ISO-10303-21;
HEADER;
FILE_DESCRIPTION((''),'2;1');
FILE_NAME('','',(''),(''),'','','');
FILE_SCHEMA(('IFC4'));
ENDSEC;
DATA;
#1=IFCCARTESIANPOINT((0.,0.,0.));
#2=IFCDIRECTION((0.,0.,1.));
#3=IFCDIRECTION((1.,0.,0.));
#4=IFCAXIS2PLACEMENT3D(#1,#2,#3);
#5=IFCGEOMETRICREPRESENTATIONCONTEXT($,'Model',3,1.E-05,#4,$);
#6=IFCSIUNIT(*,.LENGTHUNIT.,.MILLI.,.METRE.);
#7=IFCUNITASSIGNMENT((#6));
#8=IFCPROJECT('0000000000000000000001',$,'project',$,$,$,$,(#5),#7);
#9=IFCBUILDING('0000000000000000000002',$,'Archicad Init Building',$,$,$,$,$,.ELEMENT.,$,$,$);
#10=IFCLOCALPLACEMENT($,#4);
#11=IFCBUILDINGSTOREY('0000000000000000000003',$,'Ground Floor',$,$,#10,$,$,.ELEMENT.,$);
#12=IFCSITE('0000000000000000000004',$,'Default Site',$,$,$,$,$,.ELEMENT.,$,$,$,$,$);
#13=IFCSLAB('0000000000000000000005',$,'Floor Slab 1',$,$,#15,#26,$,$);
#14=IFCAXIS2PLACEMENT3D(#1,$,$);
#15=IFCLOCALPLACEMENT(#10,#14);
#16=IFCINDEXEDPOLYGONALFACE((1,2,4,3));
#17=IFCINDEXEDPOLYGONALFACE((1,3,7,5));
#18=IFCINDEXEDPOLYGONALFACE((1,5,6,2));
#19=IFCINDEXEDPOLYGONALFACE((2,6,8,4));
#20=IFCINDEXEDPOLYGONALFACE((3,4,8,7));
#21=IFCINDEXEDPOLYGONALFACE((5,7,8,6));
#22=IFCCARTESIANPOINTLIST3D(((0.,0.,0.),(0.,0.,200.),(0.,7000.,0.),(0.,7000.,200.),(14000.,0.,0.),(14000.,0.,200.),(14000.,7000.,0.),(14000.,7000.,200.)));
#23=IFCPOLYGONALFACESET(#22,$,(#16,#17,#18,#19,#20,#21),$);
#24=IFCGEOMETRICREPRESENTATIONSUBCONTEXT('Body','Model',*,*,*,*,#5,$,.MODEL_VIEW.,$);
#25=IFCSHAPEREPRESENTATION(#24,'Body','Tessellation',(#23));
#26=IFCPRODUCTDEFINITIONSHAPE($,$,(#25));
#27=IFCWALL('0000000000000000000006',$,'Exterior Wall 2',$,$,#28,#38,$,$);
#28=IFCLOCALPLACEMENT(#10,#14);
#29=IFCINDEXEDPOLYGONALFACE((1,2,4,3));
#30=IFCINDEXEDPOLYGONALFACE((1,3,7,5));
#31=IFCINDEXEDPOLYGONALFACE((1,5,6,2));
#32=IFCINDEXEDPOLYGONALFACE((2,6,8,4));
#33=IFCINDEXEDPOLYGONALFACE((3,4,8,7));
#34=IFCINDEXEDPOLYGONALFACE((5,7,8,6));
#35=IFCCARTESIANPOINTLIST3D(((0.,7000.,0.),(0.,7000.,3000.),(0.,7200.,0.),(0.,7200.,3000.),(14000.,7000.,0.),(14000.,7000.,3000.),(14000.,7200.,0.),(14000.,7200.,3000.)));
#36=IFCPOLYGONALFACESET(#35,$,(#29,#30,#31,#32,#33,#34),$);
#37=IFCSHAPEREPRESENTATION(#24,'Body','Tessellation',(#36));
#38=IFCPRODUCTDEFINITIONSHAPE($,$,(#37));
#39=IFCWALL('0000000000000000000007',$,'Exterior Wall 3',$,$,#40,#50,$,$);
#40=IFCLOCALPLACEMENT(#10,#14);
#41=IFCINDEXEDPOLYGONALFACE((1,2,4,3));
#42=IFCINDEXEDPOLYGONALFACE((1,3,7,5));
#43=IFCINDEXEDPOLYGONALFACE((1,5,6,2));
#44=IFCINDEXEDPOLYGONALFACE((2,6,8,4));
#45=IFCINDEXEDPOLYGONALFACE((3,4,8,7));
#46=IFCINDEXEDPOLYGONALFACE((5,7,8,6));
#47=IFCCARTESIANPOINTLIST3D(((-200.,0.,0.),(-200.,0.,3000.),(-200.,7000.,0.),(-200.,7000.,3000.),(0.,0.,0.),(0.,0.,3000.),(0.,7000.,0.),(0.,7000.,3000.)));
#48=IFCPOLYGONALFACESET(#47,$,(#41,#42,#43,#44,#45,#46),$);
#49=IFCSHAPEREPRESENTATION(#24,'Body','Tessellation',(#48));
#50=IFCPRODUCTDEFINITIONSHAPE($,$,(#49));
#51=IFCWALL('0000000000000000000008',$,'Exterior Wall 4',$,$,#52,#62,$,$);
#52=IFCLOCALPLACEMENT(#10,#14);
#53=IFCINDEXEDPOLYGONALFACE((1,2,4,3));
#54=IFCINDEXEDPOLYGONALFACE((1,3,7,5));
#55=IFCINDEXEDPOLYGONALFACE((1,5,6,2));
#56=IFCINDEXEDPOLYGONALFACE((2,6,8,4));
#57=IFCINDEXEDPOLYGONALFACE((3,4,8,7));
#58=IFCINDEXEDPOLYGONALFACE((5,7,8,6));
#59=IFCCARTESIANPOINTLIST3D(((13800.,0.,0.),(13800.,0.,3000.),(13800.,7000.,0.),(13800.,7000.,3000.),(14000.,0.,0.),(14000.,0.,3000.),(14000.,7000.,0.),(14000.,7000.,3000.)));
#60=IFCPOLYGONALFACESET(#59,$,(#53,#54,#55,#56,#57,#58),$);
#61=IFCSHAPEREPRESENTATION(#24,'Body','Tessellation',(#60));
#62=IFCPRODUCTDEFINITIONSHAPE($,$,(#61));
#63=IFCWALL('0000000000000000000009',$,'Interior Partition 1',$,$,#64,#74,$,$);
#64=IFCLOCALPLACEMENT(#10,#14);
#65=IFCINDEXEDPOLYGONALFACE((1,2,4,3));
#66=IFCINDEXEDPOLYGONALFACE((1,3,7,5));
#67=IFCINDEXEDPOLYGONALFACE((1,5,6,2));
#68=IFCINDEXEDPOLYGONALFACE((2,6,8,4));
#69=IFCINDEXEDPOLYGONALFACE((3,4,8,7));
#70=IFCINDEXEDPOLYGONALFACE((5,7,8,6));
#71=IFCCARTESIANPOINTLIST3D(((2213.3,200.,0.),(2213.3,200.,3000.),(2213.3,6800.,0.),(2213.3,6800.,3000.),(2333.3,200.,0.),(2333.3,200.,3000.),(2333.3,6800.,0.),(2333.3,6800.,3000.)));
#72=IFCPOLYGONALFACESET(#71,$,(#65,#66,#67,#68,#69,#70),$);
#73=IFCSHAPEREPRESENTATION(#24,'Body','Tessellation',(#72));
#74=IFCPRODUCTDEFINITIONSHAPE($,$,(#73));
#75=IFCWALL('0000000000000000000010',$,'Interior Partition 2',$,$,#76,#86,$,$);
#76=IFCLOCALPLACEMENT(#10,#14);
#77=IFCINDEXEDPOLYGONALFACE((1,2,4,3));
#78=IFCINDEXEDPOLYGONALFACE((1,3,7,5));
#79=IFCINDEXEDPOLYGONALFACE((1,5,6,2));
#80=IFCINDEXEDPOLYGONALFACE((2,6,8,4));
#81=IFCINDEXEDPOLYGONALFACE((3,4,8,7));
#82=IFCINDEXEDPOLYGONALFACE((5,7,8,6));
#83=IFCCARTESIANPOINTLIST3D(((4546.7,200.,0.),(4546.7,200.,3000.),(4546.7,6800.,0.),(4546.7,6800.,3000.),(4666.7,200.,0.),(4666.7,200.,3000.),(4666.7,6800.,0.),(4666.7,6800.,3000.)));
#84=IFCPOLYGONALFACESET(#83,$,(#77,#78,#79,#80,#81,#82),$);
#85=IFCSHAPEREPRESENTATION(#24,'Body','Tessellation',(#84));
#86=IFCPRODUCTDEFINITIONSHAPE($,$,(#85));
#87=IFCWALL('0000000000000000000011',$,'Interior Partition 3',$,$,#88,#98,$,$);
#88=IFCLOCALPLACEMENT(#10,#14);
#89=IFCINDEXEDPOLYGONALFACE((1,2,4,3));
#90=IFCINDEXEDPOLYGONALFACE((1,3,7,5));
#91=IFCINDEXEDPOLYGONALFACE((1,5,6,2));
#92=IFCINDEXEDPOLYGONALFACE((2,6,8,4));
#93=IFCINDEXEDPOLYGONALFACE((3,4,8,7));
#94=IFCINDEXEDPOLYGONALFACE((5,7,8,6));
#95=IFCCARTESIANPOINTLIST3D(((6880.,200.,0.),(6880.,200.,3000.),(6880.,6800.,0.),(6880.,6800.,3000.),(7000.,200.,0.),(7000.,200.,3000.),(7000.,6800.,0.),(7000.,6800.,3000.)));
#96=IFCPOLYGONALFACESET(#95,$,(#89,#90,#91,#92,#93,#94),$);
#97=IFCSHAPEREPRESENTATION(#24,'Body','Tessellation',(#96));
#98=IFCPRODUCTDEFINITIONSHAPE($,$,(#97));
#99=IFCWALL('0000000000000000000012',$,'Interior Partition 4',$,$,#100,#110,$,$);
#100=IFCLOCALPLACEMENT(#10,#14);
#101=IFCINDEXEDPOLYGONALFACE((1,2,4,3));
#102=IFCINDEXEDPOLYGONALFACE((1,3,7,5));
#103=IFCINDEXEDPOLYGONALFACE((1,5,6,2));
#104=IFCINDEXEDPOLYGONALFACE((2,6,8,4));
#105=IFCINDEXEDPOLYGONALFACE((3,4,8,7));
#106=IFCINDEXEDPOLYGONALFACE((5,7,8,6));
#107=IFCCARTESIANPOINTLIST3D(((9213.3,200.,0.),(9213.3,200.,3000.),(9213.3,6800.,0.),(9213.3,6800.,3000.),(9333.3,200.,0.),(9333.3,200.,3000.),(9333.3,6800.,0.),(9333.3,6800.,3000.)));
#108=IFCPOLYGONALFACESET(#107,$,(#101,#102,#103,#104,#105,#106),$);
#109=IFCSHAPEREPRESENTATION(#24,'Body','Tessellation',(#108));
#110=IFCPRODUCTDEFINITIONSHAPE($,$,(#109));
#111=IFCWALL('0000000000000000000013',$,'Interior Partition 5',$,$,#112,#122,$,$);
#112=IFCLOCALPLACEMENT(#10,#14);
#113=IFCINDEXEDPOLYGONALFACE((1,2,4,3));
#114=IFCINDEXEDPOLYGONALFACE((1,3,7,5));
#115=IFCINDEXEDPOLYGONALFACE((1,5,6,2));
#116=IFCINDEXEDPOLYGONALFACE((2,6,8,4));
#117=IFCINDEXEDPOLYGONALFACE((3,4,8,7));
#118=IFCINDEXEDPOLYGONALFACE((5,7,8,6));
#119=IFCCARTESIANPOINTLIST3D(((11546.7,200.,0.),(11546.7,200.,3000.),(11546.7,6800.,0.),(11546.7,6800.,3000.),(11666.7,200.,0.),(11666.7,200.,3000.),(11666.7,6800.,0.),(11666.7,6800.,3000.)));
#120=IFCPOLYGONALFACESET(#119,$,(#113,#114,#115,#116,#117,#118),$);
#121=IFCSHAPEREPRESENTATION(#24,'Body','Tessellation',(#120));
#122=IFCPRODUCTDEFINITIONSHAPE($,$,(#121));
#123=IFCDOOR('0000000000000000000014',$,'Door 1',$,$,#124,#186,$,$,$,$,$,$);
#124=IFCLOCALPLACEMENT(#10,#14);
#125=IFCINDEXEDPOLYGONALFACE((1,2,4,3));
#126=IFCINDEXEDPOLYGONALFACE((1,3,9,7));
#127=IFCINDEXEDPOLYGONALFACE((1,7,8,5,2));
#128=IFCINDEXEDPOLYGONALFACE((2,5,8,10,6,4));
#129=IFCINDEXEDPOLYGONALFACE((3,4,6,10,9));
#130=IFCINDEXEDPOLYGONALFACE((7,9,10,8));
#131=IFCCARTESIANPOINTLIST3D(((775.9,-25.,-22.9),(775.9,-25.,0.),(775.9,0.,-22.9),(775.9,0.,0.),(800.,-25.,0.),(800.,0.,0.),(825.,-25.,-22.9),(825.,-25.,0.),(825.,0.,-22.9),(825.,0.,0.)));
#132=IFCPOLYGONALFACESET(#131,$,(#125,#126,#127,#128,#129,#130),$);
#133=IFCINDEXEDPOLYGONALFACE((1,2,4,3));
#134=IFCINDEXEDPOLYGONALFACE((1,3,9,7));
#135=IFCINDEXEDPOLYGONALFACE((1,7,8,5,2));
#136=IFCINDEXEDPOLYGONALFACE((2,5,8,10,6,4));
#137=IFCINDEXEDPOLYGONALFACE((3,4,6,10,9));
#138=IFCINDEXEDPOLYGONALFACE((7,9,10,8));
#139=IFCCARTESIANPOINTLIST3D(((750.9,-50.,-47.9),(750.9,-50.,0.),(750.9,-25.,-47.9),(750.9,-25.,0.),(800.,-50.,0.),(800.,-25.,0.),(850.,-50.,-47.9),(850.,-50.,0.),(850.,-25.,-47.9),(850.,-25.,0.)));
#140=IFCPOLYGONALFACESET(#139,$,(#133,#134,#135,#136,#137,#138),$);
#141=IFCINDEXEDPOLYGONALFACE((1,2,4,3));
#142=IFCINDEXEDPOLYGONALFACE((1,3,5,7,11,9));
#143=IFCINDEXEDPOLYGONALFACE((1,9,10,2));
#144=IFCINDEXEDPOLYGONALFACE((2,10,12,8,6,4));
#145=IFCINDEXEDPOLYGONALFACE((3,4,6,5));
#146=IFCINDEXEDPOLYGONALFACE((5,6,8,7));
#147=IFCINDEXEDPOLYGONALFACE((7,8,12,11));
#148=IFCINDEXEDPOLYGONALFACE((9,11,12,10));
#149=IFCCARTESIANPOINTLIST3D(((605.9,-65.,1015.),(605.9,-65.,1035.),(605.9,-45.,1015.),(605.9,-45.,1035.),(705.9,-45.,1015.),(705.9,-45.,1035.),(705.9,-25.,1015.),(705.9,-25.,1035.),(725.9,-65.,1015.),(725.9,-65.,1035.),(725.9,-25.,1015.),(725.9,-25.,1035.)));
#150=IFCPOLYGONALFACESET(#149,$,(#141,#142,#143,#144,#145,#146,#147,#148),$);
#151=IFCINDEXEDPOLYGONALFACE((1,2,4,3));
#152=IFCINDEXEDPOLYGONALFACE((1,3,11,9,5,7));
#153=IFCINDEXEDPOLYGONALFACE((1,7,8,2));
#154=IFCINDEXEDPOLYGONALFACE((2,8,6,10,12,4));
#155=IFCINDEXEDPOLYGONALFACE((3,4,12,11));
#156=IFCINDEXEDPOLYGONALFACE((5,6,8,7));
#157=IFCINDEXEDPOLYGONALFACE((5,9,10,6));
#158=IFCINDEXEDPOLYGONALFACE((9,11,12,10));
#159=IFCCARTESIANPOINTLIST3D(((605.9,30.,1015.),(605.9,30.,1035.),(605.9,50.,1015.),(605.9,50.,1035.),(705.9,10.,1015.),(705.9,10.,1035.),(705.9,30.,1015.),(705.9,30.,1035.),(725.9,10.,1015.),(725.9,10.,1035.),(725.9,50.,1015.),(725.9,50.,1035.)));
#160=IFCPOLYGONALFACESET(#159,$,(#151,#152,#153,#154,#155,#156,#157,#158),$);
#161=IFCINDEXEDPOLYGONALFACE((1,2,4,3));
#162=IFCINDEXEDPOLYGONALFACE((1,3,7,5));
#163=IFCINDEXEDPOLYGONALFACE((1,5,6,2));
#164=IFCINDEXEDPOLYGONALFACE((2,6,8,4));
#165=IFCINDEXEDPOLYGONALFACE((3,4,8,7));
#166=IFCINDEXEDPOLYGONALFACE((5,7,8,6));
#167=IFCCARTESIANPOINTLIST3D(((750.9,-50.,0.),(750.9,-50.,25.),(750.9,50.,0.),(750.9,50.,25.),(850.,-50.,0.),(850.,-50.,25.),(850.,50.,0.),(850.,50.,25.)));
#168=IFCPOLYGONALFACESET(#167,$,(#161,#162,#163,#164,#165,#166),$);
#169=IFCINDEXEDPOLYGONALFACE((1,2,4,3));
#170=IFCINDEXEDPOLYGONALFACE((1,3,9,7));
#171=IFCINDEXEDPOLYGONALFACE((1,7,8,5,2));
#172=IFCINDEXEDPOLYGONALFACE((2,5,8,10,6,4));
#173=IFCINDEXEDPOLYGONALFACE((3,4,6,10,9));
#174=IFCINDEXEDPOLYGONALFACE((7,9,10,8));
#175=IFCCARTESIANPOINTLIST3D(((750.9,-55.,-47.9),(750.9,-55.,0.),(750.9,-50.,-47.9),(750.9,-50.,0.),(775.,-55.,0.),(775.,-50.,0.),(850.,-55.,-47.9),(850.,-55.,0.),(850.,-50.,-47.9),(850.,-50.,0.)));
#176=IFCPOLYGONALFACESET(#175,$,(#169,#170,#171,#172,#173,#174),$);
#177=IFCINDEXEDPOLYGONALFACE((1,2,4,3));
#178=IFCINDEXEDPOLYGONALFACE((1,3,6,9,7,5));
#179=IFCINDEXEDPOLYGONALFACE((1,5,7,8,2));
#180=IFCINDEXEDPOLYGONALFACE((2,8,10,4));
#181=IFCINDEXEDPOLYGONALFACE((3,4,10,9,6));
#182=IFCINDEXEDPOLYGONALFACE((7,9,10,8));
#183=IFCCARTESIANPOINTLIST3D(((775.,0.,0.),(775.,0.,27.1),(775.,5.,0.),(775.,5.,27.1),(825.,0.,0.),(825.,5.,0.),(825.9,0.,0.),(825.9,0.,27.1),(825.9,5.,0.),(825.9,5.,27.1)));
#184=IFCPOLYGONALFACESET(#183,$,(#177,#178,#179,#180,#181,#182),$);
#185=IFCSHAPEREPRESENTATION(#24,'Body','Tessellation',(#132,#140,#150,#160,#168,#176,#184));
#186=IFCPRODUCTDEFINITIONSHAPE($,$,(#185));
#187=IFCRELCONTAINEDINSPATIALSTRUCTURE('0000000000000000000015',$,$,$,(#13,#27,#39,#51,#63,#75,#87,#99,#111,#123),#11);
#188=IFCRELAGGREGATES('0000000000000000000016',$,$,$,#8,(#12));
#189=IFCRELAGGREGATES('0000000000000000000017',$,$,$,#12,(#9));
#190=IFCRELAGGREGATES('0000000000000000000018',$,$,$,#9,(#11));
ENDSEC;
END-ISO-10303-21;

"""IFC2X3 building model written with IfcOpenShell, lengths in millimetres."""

from ifc_helpers import new_model, si_unit, frame, origin_with_axes, place, context, subcontext, project, spatial, polyline, outline, extrude, element, save


model = new_model("IFC2X3")

# Units and contexts
model_context = context("Model", 3, precision=1e-05, world=origin_with_axes())
body_context = subcontext(model_context, "Body", "Model", "MODEL_VIEW")
ifc_project = project(units=[si_unit("LENGTHUNIT", "METRE", prefix="MILLI")], contexts=[model_context])

# Site, building, storey
site = spatial("IfcSite", under=ifc_project, Name="Default Site", CompositionType="ELEMENT")
building = spatial("IfcBuilding", under=site, Name="Archicad Init Building", CompositionType="ELEMENT")
storey_placement = place(None, origin_with_axes())
storey = spatial("IfcBuildingStorey", under=building, at=storey_placement, Name="Ground Floor", CompositionType="ELEMENT")

# Slab
slab_placement = place(storey_placement, origin_with_axes())
element("IfcSlab", 1, at=slab_placement, inside=storey, Name="Floor Slab 1", context=body_context, shape_type="SweptSolid", body=[
    extrude(outline(polyline([(0.0, 0.0), (14000.0, 0.0), (14000.0, 7000.0), (0.0, 7000.0), (0.0, 0.0)])), origin_with_axes(), (0.0, 0.0, 1.0), 200.0),
])

# Walls
wall_placement = place(storey_placement, frame((0.0, 7000.0, 0.0), z_axis=(0.0, 0.0, 1.0), x_axis=(1.0, 0.0, 0.0)))
element("IfcWall", 2, at=wall_placement, inside=storey, Name="Exterior Wall 2", context=body_context, shape_type="SweptSolid", body=[
    extrude(outline(polyline([(0.0, 0.0), (0.0, 200.0), (14000.0, 200.0), (14000.0, 0.0), (0.0, 0.0)])), origin_with_axes(), (0.0, 0.0, 1.0), 3000.0),
])
for number, where, z_axis, x_axis, name in (
    (3, (0.0, 0.0, 0.0), (0.0, 0.0, 1.0), (0.0, 1.0, 0.0), "Exterior Wall 3"),
    (4, (14000.0, 0.0, 0.0), (0.0, 0.0, 1.0), (0.0, 1.0, 0.0), "Exterior Wall 4"),
):
    element("IfcWall", number, at=place(storey_placement, frame(where, z_axis=z_axis, x_axis=x_axis)), inside=storey, Name=name, context=body_context, shape_type="SweptSolid", body=[
        extrude(outline(polyline([(0.0, 0.0), (0.0, 200.0), (7000.0, 200.0), (7000.0, 0.0), (0.0, 0.0)])), origin_with_axes(), (0.0, 0.0, 1.0), 3000.0),
    ])
for number, where, z_axis, x_axis, name in (
    (5, (2333.3, 200.0, 0.0), (0.0, 0.0, 1.0), (0.0, 1.0, 0.0), "Interior Partition 1"),
    (6, (4666.7, 200.0, 0.0), (0.0, 0.0, 1.0), (0.0, 1.0, 0.0), "Interior Partition 2"),
    (7, (7000.0, 200.0, 0.0), (0.0, 0.0, 1.0), (0.0, 1.0, 0.0), "Interior Partition 3"),
    (8, (9333.3, 200.0, 0.0), (0.0, 0.0, 1.0), (0.0, 1.0, 0.0), "Interior Partition 4"),
    (9, (11666.7, 200.0, 0.0), (0.0, 0.0, 1.0), (0.0, 1.0, 0.0), "Interior Partition 5"),
):
    element("IfcWall", number, at=place(storey_placement, frame(where, z_axis=z_axis, x_axis=x_axis)), inside=storey, Name=name, context=body_context, shape_type="SweptSolid", body=[
        extrude(outline(polyline([(0.0, 0.0), (0.0, 120.0), (6600.0, 120.0), (6600.0, 0.0), (0.0, 0.0)])), origin_with_axes(), (0.0, 0.0, 1.0), 3000.0),
    ])

# Door
door_1_placement = place(storey_placement, frame((800.0, -50.0, 0.0), z_axis=(0.0, 0.0, 1.0), x_axis=(1.0, 0.0, 0.0)))
element("IfcDoor", 10, at=door_1_placement, inside=storey, Name="Door 1", context=body_context, shape_type="SweptSolid", body=[
    extrude(outline(polyline([(0.0, 0.0), (0.0, 2.1), (0.9, 2.1), (0.9, 0.0), (-24.1, 0.0), (-24.1, -22.9), (25.0, -22.9), (25.0, 0.0), (0.0, 0.0)])), frame((0.0, 25.0, 0.0), z_axis=(0.0, -1.0, 0.0), x_axis=(1.0, 0.0, 0.0)), (0.0, 0.0, -1.0), 25.0),
    extrude(outline(polyline([(0.0, 0.0), (0.0, 2.1), (0.9, 2.1), (0.9, 0.0), (-49.1, 0.0), (-49.1, -47.9), (50.0, -47.9), (50.0, 0.0), (0.0, 0.0)])), frame((0.0, 0.0, 0.0), z_axis=(0.0, -1.0, 0.0), x_axis=(1.0, 0.0, 0.0)), (0.0, 0.0, -1.0), 25.0),
    extrude(outline(polyline([(0.0, 0.0), (-49.1, 0.0), (-49.1, 35.0), (0.0, 35.0), (0.0, 0.0)])), frame((25.0, 25.0, 25.0), z_axis=(0.0, 0.0, 1.0), x_axis=(1.0, 0.0, 0.0)), (0.0, 0.0, 1.0), -47.9),
    extrude(outline(polyline([(0.0, 0.0), (0.0, -40.0), (-120.0, -40.0), (-120.0, -20.0), (-20.0, -20.0), (-20.0, 0.0), (0.0, 0.0)])), frame((-74.1, 25.0, 1015.0), z_axis=(0.0, 0.0, 1.0), x_axis=(1.0, 0.0, 0.0)), (0.0, 0.0, 1.0), 20.0),
    extrude(outline(polyline([(0.0, 0.0), (0.0, 40.0), (-120.0, 40.0), (-120.0, 20.0), (-20.0, 20.0), (-20.0, 0.0), (0.0, 0.0)])), frame((-74.1, 60.0, 1015.0), z_axis=(0.0, 0.0, 1.0), x_axis=(1.0, 0.0, 0.0)), (0.0, 0.0, 1.0), 20.0),
    extrude(outline(polyline([(0.0, 0.0), (-99.1, 0.0), (-99.1, 100.0), (0.0, 100.0), (0.0, 0.0)])), frame((50.0, 0.0, 0.0), z_axis=(0.0, 0.0, 1.0), x_axis=(1.0, 0.0, 0.0)), (0.0, 0.0, 1.0), 25.0),
    extrude(outline(polyline([(0.0, 0.0), (0.0, 27.1), (50.9, 27.1), (50.9, 0.0), (-24.1, 0.0), (-24.1, -47.9), (75.0, -47.9), (75.0, 0.0), (0.0, 0.0)])), frame((-25.0, -5.0, 0.0), z_axis=(0.0, -1.0, 0.0), x_axis=(1.0, 0.0, 0.0)), (0.0, 0.0, -1.0), 5.0),
    extrude(outline(polyline([(0.0, 0.0), (0.0, 27.1), (50.9, 27.1), (50.9, 0.0), (0.9, 0.0), (0.9, -22.9), (50.0, -22.9), (50.0, 0.0), (0.0, 0.0)])), frame((-25.0, 50.0, 0.0), z_axis=(0.0, -1.0, 0.0), x_axis=(1.0, 0.0, 0.0)), (0.0, 0.0, -1.0), 5.0),
])

save(model, "model.ifc")
